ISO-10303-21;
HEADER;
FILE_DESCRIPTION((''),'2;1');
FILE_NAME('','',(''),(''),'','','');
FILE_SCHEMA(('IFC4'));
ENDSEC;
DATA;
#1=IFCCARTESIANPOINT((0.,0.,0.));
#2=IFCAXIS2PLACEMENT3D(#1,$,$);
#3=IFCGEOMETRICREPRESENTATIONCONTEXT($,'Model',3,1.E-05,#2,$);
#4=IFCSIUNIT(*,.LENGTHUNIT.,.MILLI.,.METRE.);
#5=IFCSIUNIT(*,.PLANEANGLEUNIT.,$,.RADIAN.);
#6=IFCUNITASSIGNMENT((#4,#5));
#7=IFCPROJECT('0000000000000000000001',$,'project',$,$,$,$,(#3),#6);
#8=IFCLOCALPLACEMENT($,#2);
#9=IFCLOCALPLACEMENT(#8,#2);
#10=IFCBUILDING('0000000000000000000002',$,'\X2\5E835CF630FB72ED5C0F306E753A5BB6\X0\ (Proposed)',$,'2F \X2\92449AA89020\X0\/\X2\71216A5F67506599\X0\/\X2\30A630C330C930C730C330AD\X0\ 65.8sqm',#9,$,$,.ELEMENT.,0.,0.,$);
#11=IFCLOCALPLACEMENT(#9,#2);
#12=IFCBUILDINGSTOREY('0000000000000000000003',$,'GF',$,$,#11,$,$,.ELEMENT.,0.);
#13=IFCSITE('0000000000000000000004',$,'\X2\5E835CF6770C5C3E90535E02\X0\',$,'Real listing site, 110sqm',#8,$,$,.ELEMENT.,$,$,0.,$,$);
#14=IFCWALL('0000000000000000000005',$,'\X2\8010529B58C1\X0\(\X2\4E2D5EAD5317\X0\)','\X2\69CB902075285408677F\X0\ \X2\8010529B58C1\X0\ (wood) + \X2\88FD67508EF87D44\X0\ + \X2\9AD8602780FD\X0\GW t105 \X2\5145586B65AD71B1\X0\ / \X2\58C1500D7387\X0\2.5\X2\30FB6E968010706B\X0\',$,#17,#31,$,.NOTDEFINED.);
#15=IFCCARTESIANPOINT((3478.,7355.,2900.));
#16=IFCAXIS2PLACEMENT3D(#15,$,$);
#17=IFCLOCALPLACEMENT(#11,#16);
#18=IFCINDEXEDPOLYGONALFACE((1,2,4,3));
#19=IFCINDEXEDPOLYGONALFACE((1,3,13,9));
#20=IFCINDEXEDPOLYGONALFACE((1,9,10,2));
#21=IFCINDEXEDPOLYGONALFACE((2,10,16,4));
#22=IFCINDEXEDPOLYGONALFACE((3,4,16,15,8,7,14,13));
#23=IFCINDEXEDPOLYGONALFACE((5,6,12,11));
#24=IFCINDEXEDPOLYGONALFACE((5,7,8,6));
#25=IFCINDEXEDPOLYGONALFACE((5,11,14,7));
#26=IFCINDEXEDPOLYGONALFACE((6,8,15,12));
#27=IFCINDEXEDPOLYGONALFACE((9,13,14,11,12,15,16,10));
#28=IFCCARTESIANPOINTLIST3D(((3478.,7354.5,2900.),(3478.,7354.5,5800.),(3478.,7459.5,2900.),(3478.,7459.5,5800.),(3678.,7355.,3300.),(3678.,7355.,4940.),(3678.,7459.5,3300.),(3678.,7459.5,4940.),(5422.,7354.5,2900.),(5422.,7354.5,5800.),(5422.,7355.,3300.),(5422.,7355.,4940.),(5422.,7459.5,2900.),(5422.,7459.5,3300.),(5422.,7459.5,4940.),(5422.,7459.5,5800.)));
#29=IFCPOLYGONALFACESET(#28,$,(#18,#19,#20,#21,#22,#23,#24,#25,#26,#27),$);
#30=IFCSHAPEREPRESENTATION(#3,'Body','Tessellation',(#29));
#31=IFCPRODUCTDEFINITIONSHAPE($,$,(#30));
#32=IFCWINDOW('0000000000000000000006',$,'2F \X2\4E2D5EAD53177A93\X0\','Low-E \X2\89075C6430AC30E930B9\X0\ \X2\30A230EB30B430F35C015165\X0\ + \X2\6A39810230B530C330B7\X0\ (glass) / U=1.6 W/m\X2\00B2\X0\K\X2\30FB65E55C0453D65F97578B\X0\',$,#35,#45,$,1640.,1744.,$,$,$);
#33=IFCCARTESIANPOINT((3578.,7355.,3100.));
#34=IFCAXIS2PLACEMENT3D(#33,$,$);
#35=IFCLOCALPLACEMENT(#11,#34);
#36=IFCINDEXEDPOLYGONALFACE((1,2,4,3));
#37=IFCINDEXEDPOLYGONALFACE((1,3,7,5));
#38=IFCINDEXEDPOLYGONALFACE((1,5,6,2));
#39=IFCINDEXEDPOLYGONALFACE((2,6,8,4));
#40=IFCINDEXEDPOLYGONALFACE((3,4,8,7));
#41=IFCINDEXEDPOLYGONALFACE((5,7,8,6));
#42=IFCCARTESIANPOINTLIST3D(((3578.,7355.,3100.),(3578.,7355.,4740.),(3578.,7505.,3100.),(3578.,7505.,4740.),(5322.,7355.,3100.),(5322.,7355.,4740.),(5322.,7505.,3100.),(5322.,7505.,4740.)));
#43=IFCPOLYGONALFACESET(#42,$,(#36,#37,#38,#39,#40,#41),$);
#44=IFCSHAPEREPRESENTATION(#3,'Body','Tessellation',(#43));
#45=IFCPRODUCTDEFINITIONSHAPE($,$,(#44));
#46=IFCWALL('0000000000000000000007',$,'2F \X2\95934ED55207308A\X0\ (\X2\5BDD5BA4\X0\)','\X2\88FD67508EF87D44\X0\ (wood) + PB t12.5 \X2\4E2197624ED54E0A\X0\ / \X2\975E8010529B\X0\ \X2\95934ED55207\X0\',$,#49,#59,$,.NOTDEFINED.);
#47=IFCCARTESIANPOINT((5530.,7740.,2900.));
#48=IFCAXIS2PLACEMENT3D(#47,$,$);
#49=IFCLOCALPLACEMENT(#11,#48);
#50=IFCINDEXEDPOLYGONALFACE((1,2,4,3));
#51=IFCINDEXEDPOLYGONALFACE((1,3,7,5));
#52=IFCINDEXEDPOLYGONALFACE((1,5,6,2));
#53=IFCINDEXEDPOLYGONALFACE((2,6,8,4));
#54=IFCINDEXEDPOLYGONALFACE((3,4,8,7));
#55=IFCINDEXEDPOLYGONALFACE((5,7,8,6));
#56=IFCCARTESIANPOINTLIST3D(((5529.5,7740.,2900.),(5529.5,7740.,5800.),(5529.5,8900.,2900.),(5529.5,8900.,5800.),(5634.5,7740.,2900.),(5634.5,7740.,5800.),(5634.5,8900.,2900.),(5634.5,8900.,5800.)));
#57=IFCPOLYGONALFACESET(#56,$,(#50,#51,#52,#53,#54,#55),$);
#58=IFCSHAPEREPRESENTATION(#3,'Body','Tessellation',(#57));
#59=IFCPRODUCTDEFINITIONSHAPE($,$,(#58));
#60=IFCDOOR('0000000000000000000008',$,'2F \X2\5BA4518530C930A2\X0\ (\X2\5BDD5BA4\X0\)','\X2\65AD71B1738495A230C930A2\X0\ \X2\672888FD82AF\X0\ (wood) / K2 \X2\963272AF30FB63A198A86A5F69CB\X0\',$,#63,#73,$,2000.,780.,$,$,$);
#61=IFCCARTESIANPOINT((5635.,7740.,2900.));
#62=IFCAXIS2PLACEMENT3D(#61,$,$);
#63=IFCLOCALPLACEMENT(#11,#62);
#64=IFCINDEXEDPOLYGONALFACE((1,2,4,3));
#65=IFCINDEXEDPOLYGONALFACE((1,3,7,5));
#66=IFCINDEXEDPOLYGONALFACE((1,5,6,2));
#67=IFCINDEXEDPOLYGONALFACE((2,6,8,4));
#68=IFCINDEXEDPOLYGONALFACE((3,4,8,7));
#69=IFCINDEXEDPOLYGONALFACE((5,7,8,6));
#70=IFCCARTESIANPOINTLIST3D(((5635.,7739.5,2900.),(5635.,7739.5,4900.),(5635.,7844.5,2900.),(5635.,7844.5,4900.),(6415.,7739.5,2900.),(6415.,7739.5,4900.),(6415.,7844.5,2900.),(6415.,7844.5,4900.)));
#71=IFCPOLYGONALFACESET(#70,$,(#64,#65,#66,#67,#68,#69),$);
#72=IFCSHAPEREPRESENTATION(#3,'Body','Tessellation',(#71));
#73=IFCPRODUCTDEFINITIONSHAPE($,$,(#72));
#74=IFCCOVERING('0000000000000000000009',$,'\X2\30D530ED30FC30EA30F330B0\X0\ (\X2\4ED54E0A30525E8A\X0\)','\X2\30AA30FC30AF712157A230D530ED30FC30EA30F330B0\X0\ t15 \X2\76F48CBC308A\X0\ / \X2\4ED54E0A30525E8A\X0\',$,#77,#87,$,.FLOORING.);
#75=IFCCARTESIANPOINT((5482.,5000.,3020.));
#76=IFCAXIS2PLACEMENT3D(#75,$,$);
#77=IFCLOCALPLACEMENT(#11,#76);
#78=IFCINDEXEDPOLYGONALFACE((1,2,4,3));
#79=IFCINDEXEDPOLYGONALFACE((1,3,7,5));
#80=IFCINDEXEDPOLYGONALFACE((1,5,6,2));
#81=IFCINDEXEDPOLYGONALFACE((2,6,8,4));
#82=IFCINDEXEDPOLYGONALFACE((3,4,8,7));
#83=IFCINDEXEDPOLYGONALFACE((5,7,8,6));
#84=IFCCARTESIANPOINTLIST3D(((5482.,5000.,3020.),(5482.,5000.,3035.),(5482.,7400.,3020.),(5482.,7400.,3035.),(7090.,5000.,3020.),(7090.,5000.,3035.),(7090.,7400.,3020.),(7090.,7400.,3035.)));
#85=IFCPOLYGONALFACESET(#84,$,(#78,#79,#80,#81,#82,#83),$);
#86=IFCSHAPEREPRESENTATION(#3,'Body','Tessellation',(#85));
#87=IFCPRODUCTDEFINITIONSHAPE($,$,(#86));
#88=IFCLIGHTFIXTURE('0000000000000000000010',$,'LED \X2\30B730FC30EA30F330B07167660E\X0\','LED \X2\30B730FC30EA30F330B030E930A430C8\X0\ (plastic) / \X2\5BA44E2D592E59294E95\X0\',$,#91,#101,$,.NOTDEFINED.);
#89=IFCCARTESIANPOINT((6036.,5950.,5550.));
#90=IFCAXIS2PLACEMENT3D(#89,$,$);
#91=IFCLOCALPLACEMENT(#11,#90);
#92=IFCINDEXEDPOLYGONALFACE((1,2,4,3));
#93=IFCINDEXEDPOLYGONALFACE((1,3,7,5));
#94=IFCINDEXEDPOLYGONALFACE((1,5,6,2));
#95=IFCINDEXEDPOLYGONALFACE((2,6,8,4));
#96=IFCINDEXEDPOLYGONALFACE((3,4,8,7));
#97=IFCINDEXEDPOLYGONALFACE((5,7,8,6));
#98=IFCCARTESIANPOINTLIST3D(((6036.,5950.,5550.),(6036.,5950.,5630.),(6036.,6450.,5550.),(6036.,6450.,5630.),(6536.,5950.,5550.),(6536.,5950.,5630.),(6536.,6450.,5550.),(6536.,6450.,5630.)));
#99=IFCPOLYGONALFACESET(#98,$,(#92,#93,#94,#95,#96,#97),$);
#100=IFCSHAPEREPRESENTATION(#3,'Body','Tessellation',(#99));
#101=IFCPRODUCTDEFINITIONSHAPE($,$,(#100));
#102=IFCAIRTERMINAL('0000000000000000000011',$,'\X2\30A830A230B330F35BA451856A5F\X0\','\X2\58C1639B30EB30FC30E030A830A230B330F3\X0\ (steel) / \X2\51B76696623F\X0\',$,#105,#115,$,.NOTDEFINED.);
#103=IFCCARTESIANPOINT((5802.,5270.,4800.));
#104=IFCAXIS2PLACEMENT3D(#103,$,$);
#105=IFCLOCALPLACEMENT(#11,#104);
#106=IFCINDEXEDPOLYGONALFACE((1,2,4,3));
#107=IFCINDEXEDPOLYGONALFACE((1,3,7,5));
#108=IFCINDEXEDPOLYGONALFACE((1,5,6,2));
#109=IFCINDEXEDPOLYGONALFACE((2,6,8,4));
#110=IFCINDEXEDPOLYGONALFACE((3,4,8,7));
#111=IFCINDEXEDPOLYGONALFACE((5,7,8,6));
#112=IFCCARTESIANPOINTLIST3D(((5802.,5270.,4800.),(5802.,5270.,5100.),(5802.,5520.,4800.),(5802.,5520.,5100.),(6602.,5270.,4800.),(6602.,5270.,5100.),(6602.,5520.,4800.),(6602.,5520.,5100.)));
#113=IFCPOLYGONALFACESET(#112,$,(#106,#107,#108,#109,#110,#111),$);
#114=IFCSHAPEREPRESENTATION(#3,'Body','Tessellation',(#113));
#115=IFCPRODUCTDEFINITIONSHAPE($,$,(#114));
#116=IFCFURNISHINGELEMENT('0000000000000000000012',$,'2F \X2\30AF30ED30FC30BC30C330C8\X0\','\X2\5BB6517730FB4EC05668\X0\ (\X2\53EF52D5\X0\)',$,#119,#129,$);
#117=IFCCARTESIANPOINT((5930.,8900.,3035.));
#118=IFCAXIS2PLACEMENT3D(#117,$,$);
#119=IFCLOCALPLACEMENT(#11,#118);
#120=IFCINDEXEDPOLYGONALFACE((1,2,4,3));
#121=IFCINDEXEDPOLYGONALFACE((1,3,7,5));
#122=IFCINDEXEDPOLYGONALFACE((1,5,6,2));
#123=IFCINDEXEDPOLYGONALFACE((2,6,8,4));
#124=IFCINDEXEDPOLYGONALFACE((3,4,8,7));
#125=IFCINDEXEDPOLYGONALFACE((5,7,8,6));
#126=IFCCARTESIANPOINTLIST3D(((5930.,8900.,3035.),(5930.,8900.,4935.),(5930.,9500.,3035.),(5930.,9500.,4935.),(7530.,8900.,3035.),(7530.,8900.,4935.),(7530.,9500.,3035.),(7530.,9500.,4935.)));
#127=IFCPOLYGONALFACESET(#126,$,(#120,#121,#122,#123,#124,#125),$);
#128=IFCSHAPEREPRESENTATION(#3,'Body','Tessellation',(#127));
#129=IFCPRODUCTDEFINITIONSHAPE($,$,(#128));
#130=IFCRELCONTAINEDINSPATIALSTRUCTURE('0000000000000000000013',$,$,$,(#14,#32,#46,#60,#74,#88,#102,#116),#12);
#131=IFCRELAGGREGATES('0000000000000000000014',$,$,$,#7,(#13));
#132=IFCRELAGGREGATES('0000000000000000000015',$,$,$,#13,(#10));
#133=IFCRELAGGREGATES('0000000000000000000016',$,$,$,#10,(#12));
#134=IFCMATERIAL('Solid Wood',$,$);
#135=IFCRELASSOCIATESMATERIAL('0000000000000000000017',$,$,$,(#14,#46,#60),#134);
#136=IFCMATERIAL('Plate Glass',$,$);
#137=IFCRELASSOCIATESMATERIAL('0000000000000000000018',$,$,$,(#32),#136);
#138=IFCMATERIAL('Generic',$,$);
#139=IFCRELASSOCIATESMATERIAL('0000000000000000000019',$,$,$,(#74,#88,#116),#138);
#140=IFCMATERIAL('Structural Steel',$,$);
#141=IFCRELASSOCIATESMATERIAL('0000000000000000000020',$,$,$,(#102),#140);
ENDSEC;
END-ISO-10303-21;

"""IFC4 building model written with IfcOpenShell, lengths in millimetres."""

from ifc_helpers import new_model, si_unit, frame, frame_2d, origin, place, context, project, spatial, rectangle, extrude, material, element, fill, save


model = new_model("IFC4")

# Units and contexts
model_context = context("Model", 3, precision=1e-05, world=origin())
ifc_project = project(units=[si_unit("LENGTHUNIT", "METRE", prefix="MILLI"), si_unit("PLANEANGLEUNIT", "RADIAN")], contexts=[model_context])

# Site, building, storey
site_placement = place(None, origin())
site = spatial("IfcSite", under=ifc_project, at=site_placement, Name="広島県尾道市", ObjectType="Real listing site, 110sqm", CompositionType="ELEMENT", RefElevation=0.0)
building_placement = place(site_placement, origin())
building = spatial("IfcBuilding", under=site, at=building_placement, Name="広島・狭小の町家 (Proposed)", ObjectType="2F 鉄骨造/無機材料/ウッドデッキ 65.8sqm", CompositionType="ELEMENT", ElevationOfRefHeight=0.0, ElevationOfTerrain=0.0)
storey_placement = place(building_placement, origin())
storey = spatial("IfcBuildingStorey", under=building, at=storey_placement, Name="GF", CompositionType="ELEMENT", Elevation=0.0)

# Shared definitions
ifc_material_1 = material(Name="Solid Wood")

# Wall, opening, window
wall_1_placement = place(storey_placement, frame((3478.0, 7355.0, 2900.0)))
wall_1 = element("IfcWall", 1, at=wall_1_placement, inside=storey, material=ifc_material_1, Name="耐力壁(中庭北)", Description="構造用合板 耐力壁 (wood) + 製材軸組 + 高性能GW t105 充填断熱 / 壁倍率2.5・準耐火", PredefinedType="NOTDEFINED", context=model_context, shape_type="SweptSolid", body=[
    extrude(rectangle(XDim=1944.0, YDim=105.0, at=frame_2d((972.0, 52.0))), frame((3478.0, 7355.0, 2900.0)), (0.0, 0.0, 1.0), 2900.0),
])
opening_placement = place(storey_placement, frame((3578.0, 7355.0, 3100.0)))
opening = element("IfcOpeningElement", 2, at=opening_placement, cuts=wall_1, PredefinedType="NOTDEFINED", context=model_context, shape_type="SweptSolid", body=[
    extrude(rectangle(XDim=1744.0, YDim=150.0, at=frame_2d((872.0, 75.0))), frame((3578.0, 7355.0, 3100.0)), (0.0, 0.0, 1.0), 1640.0),
])
ifc_material_2 = material(Name="Plate Glass")
window_placement = place(storey_placement, frame((3578.0, 7355.0, 3100.0)))
window = element("IfcWindow", 3, at=window_placement, inside=storey, material=ifc_material_2, Name="2F 中庭北窓", Description="Low-E 複層ガラス アルゴン封入 + 樹脂サッシ (glass) / U=1.6 W/m²K・日射取得型", OverallHeight=1640.0, OverallWidth=1744.0, context=model_context, shape_type="SweptSolid", body=[
    extrude(rectangle(XDim=1744.0, YDim=150.0, at=frame_2d((872.0, 75.0))), frame((3578.0, 7355.0, 3100.0)), (0.0, 0.0, 1.0), 1640.0),
])
fill(opening, window)

# Wall
wall_2_placement = place(storey_placement, frame((5530.0, 7740.0, 2900.0)))
element("IfcWall", 4, at=wall_2_placement, inside=storey, material=ifc_material_1, Name="2F 間仕切り (寝室)", Description="製材軸組 (wood) + PB t12.5 両面仕上 / 非耐力 間仕切", PredefinedType="NOTDEFINED", context=model_context, shape_type="SweptSolid", body=[
    extrude(rectangle(XDim=105.0, YDim=1160.0, at=frame_2d((52.0, 580.0))), frame((5530.0, 7740.0, 2900.0)), (0.0, 0.0, 1.0), 2900.0),
])

# Door
door_placement = place(storey_placement, frame((5635.0, 7740.0, 2900.0)))
element("IfcDoor", 5, at=door_placement, inside=storey, material=ifc_material_1, Name="2F 室内ドア (寝室)", Description="断熱玄関ドア 木製芯 (wood) / K2 防犯・採風機構", OverallHeight=2000.0, OverallWidth=780.0, context=model_context, shape_type="SweptSolid", body=[
    extrude(rectangle(XDim=780.0, YDim=105.0, at=frame_2d((390.0, 52.0))), frame((5635.0, 7740.0, 2900.0)), (0.0, 0.0, 1.0), 2000.0),
])

# Covering
ifc_material_3 = material(Name="Generic")
covering_placement = place(storey_placement, frame((5482.0, 5000.0, 3020.0)))
element("IfcCovering", 6, at=covering_placement, inside=storey, material=ifc_material_3, Name="フローリング (仕上げ床)", Description="オーク無垢フローリング t15 直貼り / 仕上げ床", PredefinedType="FLOORING", context=model_context, shape_type="SweptSolid", body=[
    extrude(rectangle(XDim=1608.0, YDim=2400.0, at=frame_2d((804.0, 1200.0))), frame((5482.0, 5000.0, 3020.0)), (0.0, 0.0, 1.0), 15.0),
])

# Light fixture
light_fixture_placement = place(storey_placement, frame((6036.0, 5950.0, 5550.0)))
element("IfcLightFixture", 7, at=light_fixture_placement, inside=storey, material=ifc_material_3, Name="LED シーリング照明", Description="LED シーリングライト (plastic) / 室中央天井", PredefinedType="NOTDEFINED", context=model_context, shape_type="SweptSolid", body=[
    extrude(rectangle(XDim=500.0, YDim=500.0, at=frame_2d((250.0, 250.0))), frame((6036.0, 5950.0, 5550.0)), (0.0, 0.0, 1.0), 80.0),
])

# Air terminal
ifc_material_4 = material(Name="Structural Steel")
air_terminal_placement = place(storey_placement, frame((5802.0, 5270.0, 4800.0)))
element("IfcAirTerminal", 8, at=air_terminal_placement, inside=storey, material=ifc_material_4, Name="エアコン室内機", Description="壁掛ルームエアコン (steel) / 冷暖房", PredefinedType="NOTDEFINED", context=model_context, shape_type="SweptSolid", body=[
    extrude(rectangle(XDim=800.0, YDim=250.0, at=frame_2d((400.0, 125.0))), frame((5802.0, 5270.0, 4800.0)), (0.0, 0.0, 1.0), 300.0),
])

# Furnishing element
furnishing_placement = place(storey_placement, frame((5930.0, 8900.0, 3035.0)))
element("IfcFurnishingElement", 9, at=furnishing_placement, inside=storey, material=ifc_material_3, Name="2F クローゼット", Description="家具・什器 (可動)", context=model_context, shape_type="SweptSolid", body=[
    extrude(rectangle(XDim=1600.0, YDim=600.0, at=frame_2d((800.0, 300.0))), frame((5930.0, 8900.0, 3035.0)), (0.0, 0.0, 1.0), 1900.0),
])

save(model, "model.ifc")
